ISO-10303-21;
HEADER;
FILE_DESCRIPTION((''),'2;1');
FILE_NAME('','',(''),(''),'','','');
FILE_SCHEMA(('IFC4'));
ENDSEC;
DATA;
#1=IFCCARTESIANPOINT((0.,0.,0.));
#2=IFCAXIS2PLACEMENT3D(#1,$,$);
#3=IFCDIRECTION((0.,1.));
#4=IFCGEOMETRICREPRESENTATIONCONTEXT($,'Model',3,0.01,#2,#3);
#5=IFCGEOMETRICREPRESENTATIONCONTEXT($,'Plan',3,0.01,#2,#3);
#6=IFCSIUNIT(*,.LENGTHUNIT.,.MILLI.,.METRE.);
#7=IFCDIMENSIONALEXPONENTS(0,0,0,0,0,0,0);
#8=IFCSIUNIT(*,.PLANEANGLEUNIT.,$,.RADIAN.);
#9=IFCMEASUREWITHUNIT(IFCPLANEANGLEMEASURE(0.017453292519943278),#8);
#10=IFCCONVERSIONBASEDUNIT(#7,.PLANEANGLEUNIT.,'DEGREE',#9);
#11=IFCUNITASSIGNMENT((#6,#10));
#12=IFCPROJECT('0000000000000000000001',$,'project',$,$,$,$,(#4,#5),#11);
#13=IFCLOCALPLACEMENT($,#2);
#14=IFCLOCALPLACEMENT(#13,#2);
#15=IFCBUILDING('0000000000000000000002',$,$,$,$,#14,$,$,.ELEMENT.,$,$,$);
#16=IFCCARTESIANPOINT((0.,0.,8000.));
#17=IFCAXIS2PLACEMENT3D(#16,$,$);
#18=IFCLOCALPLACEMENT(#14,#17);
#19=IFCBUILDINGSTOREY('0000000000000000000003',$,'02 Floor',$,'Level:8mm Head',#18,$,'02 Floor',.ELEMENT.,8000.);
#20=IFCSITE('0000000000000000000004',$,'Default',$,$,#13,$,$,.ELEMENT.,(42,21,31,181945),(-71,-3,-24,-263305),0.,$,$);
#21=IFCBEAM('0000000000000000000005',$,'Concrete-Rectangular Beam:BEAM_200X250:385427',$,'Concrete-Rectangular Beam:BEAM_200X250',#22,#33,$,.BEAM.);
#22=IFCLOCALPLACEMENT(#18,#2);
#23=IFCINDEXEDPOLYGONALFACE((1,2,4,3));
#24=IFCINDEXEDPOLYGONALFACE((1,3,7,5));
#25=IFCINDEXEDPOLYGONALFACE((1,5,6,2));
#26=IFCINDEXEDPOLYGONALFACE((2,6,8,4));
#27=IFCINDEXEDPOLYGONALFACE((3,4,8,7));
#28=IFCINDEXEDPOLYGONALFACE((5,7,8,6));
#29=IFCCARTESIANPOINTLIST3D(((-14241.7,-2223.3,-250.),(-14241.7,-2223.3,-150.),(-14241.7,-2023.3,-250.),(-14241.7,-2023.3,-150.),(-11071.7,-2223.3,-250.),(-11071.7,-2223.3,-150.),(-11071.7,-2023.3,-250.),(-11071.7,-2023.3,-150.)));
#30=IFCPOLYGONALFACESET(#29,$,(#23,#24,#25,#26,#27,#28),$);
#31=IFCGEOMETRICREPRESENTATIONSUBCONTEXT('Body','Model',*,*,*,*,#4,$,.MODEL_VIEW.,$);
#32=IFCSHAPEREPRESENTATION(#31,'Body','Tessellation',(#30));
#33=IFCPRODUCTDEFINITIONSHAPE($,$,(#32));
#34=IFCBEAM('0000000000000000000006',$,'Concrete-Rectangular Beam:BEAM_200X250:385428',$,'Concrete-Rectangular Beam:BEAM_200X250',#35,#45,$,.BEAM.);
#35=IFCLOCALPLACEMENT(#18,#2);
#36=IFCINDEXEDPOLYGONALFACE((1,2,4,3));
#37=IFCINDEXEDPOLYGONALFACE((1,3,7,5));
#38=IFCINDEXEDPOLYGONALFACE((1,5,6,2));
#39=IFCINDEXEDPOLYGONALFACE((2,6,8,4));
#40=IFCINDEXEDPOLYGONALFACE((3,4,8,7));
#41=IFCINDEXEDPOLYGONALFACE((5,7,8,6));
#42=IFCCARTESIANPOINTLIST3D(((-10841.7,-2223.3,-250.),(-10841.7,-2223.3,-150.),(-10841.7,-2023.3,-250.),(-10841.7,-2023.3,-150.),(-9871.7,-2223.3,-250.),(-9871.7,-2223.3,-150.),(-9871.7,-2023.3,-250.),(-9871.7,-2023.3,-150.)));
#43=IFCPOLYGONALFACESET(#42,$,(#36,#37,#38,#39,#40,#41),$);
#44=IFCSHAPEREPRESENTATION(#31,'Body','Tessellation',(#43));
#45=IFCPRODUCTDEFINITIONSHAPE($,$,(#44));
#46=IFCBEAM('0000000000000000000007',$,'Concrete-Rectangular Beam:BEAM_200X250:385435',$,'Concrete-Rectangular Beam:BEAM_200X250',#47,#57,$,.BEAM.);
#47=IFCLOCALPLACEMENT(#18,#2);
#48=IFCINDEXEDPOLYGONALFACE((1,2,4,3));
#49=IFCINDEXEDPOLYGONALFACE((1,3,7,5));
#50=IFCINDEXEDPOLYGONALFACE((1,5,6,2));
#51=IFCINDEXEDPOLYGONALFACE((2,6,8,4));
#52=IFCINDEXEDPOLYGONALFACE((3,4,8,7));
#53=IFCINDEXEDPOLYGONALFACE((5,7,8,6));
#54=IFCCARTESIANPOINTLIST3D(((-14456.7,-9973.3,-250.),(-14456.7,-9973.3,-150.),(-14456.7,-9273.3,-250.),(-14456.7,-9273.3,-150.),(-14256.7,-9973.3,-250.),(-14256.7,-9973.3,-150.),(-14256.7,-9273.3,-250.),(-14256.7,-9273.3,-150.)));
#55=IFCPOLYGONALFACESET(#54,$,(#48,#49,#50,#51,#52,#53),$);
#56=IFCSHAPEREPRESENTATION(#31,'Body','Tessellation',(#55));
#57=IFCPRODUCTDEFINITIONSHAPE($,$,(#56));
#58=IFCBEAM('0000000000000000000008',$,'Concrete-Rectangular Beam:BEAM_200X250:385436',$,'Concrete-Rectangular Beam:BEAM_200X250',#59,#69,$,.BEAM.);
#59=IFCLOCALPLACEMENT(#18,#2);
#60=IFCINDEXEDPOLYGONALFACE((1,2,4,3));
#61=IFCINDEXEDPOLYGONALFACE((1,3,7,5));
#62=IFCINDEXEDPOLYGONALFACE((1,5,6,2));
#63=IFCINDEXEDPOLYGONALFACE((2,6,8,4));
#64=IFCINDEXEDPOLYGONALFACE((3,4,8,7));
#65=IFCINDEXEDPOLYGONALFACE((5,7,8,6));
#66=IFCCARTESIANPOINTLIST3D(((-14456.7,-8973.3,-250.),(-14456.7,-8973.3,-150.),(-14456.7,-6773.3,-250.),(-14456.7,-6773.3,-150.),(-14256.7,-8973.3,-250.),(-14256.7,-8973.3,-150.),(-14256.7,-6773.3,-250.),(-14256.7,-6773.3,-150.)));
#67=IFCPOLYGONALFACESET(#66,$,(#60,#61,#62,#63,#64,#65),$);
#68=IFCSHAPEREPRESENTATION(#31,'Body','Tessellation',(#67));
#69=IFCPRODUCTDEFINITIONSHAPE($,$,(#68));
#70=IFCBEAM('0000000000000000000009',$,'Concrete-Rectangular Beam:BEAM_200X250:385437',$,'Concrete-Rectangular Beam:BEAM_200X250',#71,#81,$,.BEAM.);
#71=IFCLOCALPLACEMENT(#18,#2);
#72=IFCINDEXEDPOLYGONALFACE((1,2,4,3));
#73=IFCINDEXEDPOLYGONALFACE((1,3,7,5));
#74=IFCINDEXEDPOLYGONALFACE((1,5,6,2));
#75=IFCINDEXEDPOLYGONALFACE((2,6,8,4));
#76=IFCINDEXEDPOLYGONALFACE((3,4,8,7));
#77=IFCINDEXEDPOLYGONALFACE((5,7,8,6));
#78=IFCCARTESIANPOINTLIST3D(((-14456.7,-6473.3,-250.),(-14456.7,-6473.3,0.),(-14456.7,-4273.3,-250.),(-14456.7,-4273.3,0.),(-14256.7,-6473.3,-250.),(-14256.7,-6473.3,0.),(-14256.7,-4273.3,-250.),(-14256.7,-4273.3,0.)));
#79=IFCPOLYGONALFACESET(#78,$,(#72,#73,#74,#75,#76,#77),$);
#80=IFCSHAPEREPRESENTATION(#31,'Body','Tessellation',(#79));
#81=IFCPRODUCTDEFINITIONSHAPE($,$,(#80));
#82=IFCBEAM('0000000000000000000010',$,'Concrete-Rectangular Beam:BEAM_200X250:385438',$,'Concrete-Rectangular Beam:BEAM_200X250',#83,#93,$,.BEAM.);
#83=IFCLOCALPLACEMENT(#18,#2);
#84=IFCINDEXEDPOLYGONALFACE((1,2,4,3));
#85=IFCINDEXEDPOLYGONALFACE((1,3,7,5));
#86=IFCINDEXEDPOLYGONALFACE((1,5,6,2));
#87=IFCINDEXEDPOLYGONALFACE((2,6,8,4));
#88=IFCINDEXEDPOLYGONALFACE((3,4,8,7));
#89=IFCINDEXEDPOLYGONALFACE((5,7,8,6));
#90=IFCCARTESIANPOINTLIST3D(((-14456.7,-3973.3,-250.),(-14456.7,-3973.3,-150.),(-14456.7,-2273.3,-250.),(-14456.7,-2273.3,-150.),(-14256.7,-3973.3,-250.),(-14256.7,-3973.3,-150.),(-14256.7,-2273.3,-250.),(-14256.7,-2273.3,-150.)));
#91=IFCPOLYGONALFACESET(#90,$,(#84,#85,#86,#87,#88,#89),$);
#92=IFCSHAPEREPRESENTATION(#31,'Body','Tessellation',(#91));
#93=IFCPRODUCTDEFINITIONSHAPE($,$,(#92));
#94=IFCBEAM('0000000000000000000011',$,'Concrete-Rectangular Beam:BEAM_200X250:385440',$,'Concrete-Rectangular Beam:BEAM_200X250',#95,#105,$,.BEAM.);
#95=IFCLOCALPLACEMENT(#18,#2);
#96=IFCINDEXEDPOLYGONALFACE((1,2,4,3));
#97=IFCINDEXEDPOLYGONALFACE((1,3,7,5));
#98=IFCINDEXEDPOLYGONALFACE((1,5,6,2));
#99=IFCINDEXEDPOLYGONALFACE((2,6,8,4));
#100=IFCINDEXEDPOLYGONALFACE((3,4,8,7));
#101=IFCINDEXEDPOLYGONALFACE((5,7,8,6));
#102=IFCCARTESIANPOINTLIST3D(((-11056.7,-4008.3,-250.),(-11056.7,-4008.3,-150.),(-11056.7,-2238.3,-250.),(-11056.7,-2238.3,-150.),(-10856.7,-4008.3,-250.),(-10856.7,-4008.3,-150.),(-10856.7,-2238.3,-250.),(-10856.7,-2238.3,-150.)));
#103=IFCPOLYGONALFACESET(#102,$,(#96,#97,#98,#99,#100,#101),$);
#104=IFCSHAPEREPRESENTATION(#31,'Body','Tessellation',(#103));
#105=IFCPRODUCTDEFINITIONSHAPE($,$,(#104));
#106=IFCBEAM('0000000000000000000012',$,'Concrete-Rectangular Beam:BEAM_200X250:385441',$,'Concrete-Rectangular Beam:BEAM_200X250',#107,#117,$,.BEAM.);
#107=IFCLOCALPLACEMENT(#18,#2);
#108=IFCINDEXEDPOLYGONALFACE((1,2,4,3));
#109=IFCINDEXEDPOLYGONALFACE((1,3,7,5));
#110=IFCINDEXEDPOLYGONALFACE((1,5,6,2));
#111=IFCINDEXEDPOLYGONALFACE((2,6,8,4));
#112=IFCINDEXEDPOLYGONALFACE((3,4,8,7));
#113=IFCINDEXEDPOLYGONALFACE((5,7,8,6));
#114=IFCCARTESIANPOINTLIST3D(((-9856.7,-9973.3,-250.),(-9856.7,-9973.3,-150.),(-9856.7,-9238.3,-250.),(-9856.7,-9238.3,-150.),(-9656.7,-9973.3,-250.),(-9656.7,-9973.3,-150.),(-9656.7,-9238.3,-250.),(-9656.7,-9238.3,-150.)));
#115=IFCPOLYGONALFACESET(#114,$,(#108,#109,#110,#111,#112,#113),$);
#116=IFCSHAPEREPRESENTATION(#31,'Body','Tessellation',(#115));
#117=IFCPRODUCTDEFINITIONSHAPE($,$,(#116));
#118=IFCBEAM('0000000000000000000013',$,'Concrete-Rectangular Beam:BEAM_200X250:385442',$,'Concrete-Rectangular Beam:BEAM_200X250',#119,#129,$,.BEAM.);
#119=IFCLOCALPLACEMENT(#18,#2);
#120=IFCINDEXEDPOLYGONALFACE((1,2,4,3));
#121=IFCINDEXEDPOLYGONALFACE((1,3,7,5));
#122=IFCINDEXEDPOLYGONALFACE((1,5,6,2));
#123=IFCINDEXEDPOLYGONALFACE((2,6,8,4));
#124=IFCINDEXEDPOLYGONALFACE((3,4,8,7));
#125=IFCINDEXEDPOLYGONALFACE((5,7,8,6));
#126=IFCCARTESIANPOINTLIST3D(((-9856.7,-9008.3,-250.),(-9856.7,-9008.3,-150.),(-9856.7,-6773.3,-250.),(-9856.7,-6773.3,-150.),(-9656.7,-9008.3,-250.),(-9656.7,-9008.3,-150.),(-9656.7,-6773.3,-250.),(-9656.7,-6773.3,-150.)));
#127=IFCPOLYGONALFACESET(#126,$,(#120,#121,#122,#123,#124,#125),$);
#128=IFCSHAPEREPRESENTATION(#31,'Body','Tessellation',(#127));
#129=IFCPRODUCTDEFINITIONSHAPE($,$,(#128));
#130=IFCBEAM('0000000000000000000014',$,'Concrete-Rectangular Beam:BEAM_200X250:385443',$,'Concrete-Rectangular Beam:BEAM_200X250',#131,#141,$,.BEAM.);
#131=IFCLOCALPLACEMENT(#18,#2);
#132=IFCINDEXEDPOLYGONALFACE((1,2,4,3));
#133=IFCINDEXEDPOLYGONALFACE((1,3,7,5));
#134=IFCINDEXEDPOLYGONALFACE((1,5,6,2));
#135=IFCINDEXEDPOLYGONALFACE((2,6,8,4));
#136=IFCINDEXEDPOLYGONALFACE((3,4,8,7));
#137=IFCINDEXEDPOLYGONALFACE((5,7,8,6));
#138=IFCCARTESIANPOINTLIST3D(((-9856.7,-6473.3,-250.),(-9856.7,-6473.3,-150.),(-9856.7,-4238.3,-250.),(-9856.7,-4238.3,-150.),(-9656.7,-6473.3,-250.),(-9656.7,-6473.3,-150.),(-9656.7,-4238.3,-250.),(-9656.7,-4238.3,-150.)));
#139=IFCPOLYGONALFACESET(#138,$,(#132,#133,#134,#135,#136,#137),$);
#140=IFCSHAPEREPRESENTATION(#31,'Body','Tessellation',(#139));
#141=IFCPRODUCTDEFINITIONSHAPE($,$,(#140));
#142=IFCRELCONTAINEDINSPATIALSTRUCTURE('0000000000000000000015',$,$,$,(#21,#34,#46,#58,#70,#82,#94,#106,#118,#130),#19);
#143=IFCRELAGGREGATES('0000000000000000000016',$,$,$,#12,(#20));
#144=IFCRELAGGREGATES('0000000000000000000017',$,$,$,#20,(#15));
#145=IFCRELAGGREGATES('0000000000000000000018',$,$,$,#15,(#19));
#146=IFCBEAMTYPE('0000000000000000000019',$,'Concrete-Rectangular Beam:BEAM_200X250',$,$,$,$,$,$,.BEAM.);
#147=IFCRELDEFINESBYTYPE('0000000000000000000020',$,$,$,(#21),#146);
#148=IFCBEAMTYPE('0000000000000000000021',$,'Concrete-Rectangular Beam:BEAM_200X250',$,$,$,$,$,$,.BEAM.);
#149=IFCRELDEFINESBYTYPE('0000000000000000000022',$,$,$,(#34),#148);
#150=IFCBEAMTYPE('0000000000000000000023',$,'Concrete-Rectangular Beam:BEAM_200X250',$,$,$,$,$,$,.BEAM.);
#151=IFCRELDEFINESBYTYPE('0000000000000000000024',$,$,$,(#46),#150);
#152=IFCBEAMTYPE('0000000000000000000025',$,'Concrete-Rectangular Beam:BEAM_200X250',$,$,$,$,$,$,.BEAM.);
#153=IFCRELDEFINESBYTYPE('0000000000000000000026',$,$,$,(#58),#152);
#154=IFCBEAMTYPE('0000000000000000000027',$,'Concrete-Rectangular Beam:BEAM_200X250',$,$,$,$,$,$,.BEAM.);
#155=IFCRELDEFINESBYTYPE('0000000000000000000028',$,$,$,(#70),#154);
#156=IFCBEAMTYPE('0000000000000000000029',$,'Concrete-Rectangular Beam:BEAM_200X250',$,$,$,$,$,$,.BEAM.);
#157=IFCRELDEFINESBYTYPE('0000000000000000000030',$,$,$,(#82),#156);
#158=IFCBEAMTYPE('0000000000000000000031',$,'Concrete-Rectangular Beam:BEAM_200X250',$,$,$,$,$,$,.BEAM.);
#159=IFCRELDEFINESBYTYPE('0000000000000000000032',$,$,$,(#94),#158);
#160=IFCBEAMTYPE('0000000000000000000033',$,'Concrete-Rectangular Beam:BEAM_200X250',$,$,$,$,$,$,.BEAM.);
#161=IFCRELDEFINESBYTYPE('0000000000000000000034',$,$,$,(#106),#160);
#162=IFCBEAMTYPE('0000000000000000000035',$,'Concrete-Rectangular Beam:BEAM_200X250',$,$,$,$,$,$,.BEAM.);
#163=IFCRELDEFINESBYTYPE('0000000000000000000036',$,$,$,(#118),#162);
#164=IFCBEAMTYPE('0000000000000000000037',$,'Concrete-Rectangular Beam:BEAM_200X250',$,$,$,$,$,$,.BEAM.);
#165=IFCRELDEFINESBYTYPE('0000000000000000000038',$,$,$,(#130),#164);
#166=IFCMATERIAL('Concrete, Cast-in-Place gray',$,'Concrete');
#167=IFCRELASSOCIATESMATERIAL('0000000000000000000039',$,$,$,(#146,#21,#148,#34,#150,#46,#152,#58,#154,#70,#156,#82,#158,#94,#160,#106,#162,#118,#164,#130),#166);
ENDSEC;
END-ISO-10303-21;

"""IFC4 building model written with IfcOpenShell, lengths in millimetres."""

from ifc_helpers import new_model, entity, si_unit, converted_unit, direction, frame, origin, place, context, subcontext, project, spatial, indexed_curve, outline, extrude, source, transform, mapped, material, type_object, type_shapes, element, save


model = new_model("IFC4")

# Units and contexts
model_context = context("Model", 3, precision=0.01, world=origin(), true_north=direction((0.0, 1.0)))
plan_context = context("Plan", 3, precision=0.01, world=origin(), true_north=direction((0.0, 1.0)))
body_context = subcontext(model_context, "Body", "Model", "MODEL_VIEW")
ifc_project = project(units=[si_unit("LENGTHUNIT", "METRE", prefix="MILLI"), converted_unit("PLANEANGLEUNIT", "DEGREE", entity("IfcPlaneAngleMeasure", 0.017453292519943278), si_unit("PLANEANGLEUNIT", "RADIAN"), dimensions=[0, 0, 0, 0, 0, 0, 0])], contexts=[model_context, plan_context])

# Site, building, storey
site_placement = place(None, origin())
site = spatial("IfcSite", under=ifc_project, at=site_placement, Name="Default", CompositionType="ELEMENT", RefLatitude=(42, 21, 31, 181945), RefLongitude=(-71, -3, -24, -263305), RefElevation=0.0)
building_placement = place(site_placement, origin())
building = spatial("IfcBuilding", under=site, at=building_placement, CompositionType="ELEMENT")
storey_placement = place(building_placement, frame((0.0, 0.0, 8000.0)))
storey = spatial("IfcBuildingStorey", under=building, at=storey_placement, Name="02 Floor", ObjectType="Level:8mm Head", LongName="02 Floor", CompositionType="ELEMENT", Elevation=8000.0)

# Beams
ifc_material_1 = material(Name="Concrete, Cast-in-Place gray", Category="Concrete")
beam_type_1 = type_object("IfcBeamType", Name="Concrete-Rectangular Beam:BEAM_200X250", PredefinedType="BEAM", material=ifc_material_1)
shared_shape_1 = source(origin(), body_context, "Body", "SweptSolid", [
    extrude(outline(indexed_curve([(-50.0, -100.0), (50.0, -100.0), (50.0, 100.0), (-50.0, 100.0), (-50.0, -100.0)], self_intersect=False)), frame((-14241.7, -2123.3, 7800.0), z_axis=(1.0, 0.0, 0.0), x_axis=(0.0, 0.0, -1.0)), (0.0, 0.0, 1.0), 3170.0),
])
type_shapes(beam_type_1, [shared_shape_1])
beam_1_placement = place(storey_placement, frame((0.0, 0.0, -8000.0)))
element("IfcBeam", 1, at=beam_1_placement, inside=storey, type_object=beam_type_1, material=ifc_material_1, Name="Concrete-Rectangular Beam:BEAM_200X250:385427", ObjectType="Concrete-Rectangular Beam:BEAM_200X250", PredefinedType="BEAM", context=body_context, shape_type="MappedRepresentation", body=[
    mapped(shared_shape_1, transform((0.0, 0.0, 0.0), scale=1.0)),
])
beam_type_2 = type_object("IfcBeamType", Name="Concrete-Rectangular Beam:BEAM_200X250", PredefinedType="BEAM", material=ifc_material_1)
shared_shape_2 = source(origin(), body_context, "Body", "SweptSolid", [
    extrude(outline(indexed_curve([(-50.0, -100.0), (50.0, -100.0), (50.0, 100.0), (-50.0, 100.0), (-50.0, -100.0)], self_intersect=False)), frame((-10841.7, -2123.3, 7800.0), z_axis=(1.0, 0.0, 0.0), x_axis=(0.0, 0.0, -1.0)), (0.0, 0.0, 1.0), 970.0),
])
type_shapes(beam_type_2, [shared_shape_2])
beam_2_placement = place(storey_placement, frame((0.0, 0.0, -8000.0)))
element("IfcBeam", 2, at=beam_2_placement, inside=storey, type_object=beam_type_2, material=ifc_material_1, Name="Concrete-Rectangular Beam:BEAM_200X250:385428", ObjectType="Concrete-Rectangular Beam:BEAM_200X250", PredefinedType="BEAM", context=body_context, shape_type="MappedRepresentation", body=[
    mapped(shared_shape_2, transform((0.0, 0.0, 0.0), scale=1.0)),
])
beam_type_3 = type_object("IfcBeamType", Name="Concrete-Rectangular Beam:BEAM_200X250", PredefinedType="BEAM", material=ifc_material_1)
shared_shape_3 = source(origin(), body_context, "Body", "SweptSolid", [
    extrude(outline(indexed_curve([(-100.0, -50.0), (100.0, -50.0), (100.0, 50.0), (-100.0, 50.0), (-100.0, -50.0)], self_intersect=False)), frame((-14356.7, -9973.3, 7800.0), z_axis=(0.0, 1.0, 0.0), x_axis=(-1.0, 0.0, 0.0)), (0.0, 0.0, 1.0), 700.0),
])
type_shapes(beam_type_3, [shared_shape_3])
beam_3_placement = place(storey_placement, frame((0.0, 0.0, -8000.0)))
element("IfcBeam", 3, at=beam_3_placement, inside=storey, type_object=beam_type_3, material=ifc_material_1, Name="Concrete-Rectangular Beam:BEAM_200X250:385435", ObjectType="Concrete-Rectangular Beam:BEAM_200X250", PredefinedType="BEAM", context=body_context, shape_type="MappedRepresentation", body=[
    mapped(shared_shape_3, transform((0.0, 0.0, 0.0), scale=1.0)),
])
beam_type_4 = type_object("IfcBeamType", Name="Concrete-Rectangular Beam:BEAM_200X250", PredefinedType="BEAM", material=ifc_material_1)
shared_shape_4 = source(origin(), body_context, "Body", "SweptSolid", [
    extrude(outline(indexed_curve([(-100.0, -50.0), (100.0, -50.0), (100.0, 50.0), (-100.0, 50.0), (-100.0, -50.0)], self_intersect=False)), frame((-14356.7, -8973.3, 7800.0), z_axis=(0.0, 1.0, 0.0), x_axis=(-1.0, 0.0, 0.0)), (0.0, 0.0, 1.0), 2200.0),
])
type_shapes(beam_type_4, [shared_shape_4])
beam_4_placement = place(storey_placement, frame((0.0, 0.0, -8000.0)))
element("IfcBeam", 4, at=beam_4_placement, inside=storey, type_object=beam_type_4, material=ifc_material_1, Name="Concrete-Rectangular Beam:BEAM_200X250:385436", ObjectType="Concrete-Rectangular Beam:BEAM_200X250", PredefinedType="BEAM", context=body_context, shape_type="MappedRepresentation", body=[
    mapped(shared_shape_4, transform((0.0, 0.0, 0.0), scale=1.0)),
])
beam_type_5 = type_object("IfcBeamType", Name="Concrete-Rectangular Beam:BEAM_200X250", PredefinedType="BEAM", material=ifc_material_1)
shared_shape_5 = source(origin(), body_context, "Body", "SweptSolid", [
    extrude(outline(indexed_curve([(-100.0, -125.0), (100.0, -125.0), (100.0, 125.0), (-100.0, 125.0), (-100.0, -125.0)], self_intersect=False)), frame((-14356.7, -6473.3, 7875.0), z_axis=(0.0, 1.0, 0.0), x_axis=(-1.0, 0.0, 0.0)), (0.0, 0.0, 1.0), 2200.0),
])
type_shapes(beam_type_5, [shared_shape_5])
beam_5_placement = place(storey_placement, frame((0.0, 0.0, -8000.0)))
element("IfcBeam", 5, at=beam_5_placement, inside=storey, type_object=beam_type_5, material=ifc_material_1, Name="Concrete-Rectangular Beam:BEAM_200X250:385437", ObjectType="Concrete-Rectangular Beam:BEAM_200X250", PredefinedType="BEAM", context=body_context, shape_type="MappedRepresentation", body=[
    mapped(shared_shape_5, transform((0.0, 0.0, 0.0), scale=1.0)),
])
beam_type_6 = type_object("IfcBeamType", Name="Concrete-Rectangular Beam:BEAM_200X250", PredefinedType="BEAM", material=ifc_material_1)
shared_shape_6 = source(origin(), body_context, "Body", "SweptSolid", [
    extrude(outline(indexed_curve([(-100.0, -50.0), (100.0, -50.0), (100.0, 50.0), (-100.0, 50.0), (-100.0, -50.0)], self_intersect=False)), frame((-14356.7, -3973.3, 7800.0), z_axis=(0.0, 1.0, 0.0), x_axis=(-1.0, 0.0, 0.0)), (0.0, 0.0, 1.0), 1700.0),
])
type_shapes(beam_type_6, [shared_shape_6])
beam_6_placement = place(storey_placement, frame((0.0, 0.0, -8000.0)))
element("IfcBeam", 6, at=beam_6_placement, inside=storey, type_object=beam_type_6, material=ifc_material_1, Name="Concrete-Rectangular Beam:BEAM_200X250:385438", ObjectType="Concrete-Rectangular Beam:BEAM_200X250", PredefinedType="BEAM", context=body_context, shape_type="MappedRepresentation", body=[
    mapped(shared_shape_6, transform((0.0, 0.0, 0.0), scale=1.0)),
])
beam_type_7 = type_object("IfcBeamType", Name="Concrete-Rectangular Beam:BEAM_200X250", PredefinedType="BEAM", material=ifc_material_1)
shared_shape_7 = source(origin(), body_context, "Body", "SweptSolid", [
    extrude(outline(indexed_curve([(-100.0, -50.0), (100.0, -50.0), (100.0, 50.0), (-100.0, 50.0), (-100.0, -50.0)], self_intersect=False)), frame((-10956.7, -4008.3, 7800.0), z_axis=(0.0, 1.0, 0.0), x_axis=(-1.0, 0.0, 0.0)), (0.0, 0.0, 1.0), 1770.0),
])
type_shapes(beam_type_7, [shared_shape_7])
beam_7_placement = place(storey_placement, frame((0.0, 0.0, -8000.0)))
element("IfcBeam", 7, at=beam_7_placement, inside=storey, type_object=beam_type_7, material=ifc_material_1, Name="Concrete-Rectangular Beam:BEAM_200X250:385440", ObjectType="Concrete-Rectangular Beam:BEAM_200X250", PredefinedType="BEAM", context=body_context, shape_type="MappedRepresentation", body=[
    mapped(shared_shape_7, transform((0.0, 0.0, 0.0), scale=1.0)),
])
beam_type_8 = type_object("IfcBeamType", Name="Concrete-Rectangular Beam:BEAM_200X250", PredefinedType="BEAM", material=ifc_material_1)
shared_shape_8 = source(origin(), body_context, "Body", "SweptSolid", [
    extrude(outline(indexed_curve([(-100.0, -50.0), (100.0, -50.0), (100.0, 50.0), (-100.0, 50.0), (-100.0, -50.0)], self_intersect=False)), frame((-9756.7, -9973.3, 7800.0), z_axis=(0.0, 1.0, 0.0), x_axis=(-1.0, 0.0, 0.0)), (0.0, 0.0, 1.0), 735.0),
])
type_shapes(beam_type_8, [shared_shape_8])
beam_8_placement = place(storey_placement, frame((0.0, 0.0, -8000.0)))
element("IfcBeam", 8, at=beam_8_placement, inside=storey, type_object=beam_type_8, material=ifc_material_1, Name="Concrete-Rectangular Beam:BEAM_200X250:385441", ObjectType="Concrete-Rectangular Beam:BEAM_200X250", PredefinedType="BEAM", context=body_context, shape_type="MappedRepresentation", body=[
    mapped(shared_shape_8, transform((0.0, 0.0, 0.0), scale=1.0)),
])
beam_type_9 = type_object("IfcBeamType", Name="Concrete-Rectangular Beam:BEAM_200X250", PredefinedType="BEAM", material=ifc_material_1)
shared_shape_9 = source(origin(), body_context, "Body", "SweptSolid", [
    extrude(outline(indexed_curve([(-100.0, -50.0), (100.0, -50.0), (100.0, 50.0), (-100.0, 50.0), (-100.0, -50.0)], self_intersect=False)), frame((-9756.7, -9008.3, 7800.0), z_axis=(0.0, 1.0, 0.0), x_axis=(-1.0, 0.0, 0.0)), (0.0, 0.0, 1.0), 2235.0),
])
type_shapes(beam_type_9, [shared_shape_9])
beam_9_placement = place(storey_placement, frame((0.0, 0.0, -8000.0)))
element("IfcBeam", 9, at=beam_9_placement, inside=storey, type_object=beam_type_9, material=ifc_material_1, Name="Concrete-Rectangular Beam:BEAM_200X250:385442", ObjectType="Concrete-Rectangular Beam:BEAM_200X250", PredefinedType="BEAM", context=body_context, shape_type="MappedRepresentation", body=[
    mapped(shared_shape_9, transform((0.0, 0.0, 0.0), scale=1.0)),
])
beam_type_10 = type_object("IfcBeamType", Name="Concrete-Rectangular Beam:BEAM_200X250", PredefinedType="BEAM", material=ifc_material_1)
shared_shape_10 = source(origin(), body_context, "Body", "SweptSolid", [
    extrude(outline(indexed_curve([(-100.0, -50.0), (100.0, -50.0), (100.0, 50.0), (-100.0, 50.0), (-100.0, -50.0)], self_intersect=False)), frame((-9756.7, -6473.3, 7800.0), z_axis=(0.0, 1.0, 0.0), x_axis=(-1.0, 0.0, 0.0)), (0.0, 0.0, 1.0), 2235.0),
])
type_shapes(beam_type_10, [shared_shape_10])
beam_10_placement = place(storey_placement, frame((0.0, 0.0, -8000.0)))
element("IfcBeam", 10, at=beam_10_placement, inside=storey, type_object=beam_type_10, material=ifc_material_1, Name="Concrete-Rectangular Beam:BEAM_200X250:385443", ObjectType="Concrete-Rectangular Beam:BEAM_200X250", PredefinedType="BEAM", context=body_context, shape_type="MappedRepresentation", body=[
    mapped(shared_shape_10, transform((0.0, 0.0, 0.0), scale=1.0)),
])

save(model, "model.ifc")
